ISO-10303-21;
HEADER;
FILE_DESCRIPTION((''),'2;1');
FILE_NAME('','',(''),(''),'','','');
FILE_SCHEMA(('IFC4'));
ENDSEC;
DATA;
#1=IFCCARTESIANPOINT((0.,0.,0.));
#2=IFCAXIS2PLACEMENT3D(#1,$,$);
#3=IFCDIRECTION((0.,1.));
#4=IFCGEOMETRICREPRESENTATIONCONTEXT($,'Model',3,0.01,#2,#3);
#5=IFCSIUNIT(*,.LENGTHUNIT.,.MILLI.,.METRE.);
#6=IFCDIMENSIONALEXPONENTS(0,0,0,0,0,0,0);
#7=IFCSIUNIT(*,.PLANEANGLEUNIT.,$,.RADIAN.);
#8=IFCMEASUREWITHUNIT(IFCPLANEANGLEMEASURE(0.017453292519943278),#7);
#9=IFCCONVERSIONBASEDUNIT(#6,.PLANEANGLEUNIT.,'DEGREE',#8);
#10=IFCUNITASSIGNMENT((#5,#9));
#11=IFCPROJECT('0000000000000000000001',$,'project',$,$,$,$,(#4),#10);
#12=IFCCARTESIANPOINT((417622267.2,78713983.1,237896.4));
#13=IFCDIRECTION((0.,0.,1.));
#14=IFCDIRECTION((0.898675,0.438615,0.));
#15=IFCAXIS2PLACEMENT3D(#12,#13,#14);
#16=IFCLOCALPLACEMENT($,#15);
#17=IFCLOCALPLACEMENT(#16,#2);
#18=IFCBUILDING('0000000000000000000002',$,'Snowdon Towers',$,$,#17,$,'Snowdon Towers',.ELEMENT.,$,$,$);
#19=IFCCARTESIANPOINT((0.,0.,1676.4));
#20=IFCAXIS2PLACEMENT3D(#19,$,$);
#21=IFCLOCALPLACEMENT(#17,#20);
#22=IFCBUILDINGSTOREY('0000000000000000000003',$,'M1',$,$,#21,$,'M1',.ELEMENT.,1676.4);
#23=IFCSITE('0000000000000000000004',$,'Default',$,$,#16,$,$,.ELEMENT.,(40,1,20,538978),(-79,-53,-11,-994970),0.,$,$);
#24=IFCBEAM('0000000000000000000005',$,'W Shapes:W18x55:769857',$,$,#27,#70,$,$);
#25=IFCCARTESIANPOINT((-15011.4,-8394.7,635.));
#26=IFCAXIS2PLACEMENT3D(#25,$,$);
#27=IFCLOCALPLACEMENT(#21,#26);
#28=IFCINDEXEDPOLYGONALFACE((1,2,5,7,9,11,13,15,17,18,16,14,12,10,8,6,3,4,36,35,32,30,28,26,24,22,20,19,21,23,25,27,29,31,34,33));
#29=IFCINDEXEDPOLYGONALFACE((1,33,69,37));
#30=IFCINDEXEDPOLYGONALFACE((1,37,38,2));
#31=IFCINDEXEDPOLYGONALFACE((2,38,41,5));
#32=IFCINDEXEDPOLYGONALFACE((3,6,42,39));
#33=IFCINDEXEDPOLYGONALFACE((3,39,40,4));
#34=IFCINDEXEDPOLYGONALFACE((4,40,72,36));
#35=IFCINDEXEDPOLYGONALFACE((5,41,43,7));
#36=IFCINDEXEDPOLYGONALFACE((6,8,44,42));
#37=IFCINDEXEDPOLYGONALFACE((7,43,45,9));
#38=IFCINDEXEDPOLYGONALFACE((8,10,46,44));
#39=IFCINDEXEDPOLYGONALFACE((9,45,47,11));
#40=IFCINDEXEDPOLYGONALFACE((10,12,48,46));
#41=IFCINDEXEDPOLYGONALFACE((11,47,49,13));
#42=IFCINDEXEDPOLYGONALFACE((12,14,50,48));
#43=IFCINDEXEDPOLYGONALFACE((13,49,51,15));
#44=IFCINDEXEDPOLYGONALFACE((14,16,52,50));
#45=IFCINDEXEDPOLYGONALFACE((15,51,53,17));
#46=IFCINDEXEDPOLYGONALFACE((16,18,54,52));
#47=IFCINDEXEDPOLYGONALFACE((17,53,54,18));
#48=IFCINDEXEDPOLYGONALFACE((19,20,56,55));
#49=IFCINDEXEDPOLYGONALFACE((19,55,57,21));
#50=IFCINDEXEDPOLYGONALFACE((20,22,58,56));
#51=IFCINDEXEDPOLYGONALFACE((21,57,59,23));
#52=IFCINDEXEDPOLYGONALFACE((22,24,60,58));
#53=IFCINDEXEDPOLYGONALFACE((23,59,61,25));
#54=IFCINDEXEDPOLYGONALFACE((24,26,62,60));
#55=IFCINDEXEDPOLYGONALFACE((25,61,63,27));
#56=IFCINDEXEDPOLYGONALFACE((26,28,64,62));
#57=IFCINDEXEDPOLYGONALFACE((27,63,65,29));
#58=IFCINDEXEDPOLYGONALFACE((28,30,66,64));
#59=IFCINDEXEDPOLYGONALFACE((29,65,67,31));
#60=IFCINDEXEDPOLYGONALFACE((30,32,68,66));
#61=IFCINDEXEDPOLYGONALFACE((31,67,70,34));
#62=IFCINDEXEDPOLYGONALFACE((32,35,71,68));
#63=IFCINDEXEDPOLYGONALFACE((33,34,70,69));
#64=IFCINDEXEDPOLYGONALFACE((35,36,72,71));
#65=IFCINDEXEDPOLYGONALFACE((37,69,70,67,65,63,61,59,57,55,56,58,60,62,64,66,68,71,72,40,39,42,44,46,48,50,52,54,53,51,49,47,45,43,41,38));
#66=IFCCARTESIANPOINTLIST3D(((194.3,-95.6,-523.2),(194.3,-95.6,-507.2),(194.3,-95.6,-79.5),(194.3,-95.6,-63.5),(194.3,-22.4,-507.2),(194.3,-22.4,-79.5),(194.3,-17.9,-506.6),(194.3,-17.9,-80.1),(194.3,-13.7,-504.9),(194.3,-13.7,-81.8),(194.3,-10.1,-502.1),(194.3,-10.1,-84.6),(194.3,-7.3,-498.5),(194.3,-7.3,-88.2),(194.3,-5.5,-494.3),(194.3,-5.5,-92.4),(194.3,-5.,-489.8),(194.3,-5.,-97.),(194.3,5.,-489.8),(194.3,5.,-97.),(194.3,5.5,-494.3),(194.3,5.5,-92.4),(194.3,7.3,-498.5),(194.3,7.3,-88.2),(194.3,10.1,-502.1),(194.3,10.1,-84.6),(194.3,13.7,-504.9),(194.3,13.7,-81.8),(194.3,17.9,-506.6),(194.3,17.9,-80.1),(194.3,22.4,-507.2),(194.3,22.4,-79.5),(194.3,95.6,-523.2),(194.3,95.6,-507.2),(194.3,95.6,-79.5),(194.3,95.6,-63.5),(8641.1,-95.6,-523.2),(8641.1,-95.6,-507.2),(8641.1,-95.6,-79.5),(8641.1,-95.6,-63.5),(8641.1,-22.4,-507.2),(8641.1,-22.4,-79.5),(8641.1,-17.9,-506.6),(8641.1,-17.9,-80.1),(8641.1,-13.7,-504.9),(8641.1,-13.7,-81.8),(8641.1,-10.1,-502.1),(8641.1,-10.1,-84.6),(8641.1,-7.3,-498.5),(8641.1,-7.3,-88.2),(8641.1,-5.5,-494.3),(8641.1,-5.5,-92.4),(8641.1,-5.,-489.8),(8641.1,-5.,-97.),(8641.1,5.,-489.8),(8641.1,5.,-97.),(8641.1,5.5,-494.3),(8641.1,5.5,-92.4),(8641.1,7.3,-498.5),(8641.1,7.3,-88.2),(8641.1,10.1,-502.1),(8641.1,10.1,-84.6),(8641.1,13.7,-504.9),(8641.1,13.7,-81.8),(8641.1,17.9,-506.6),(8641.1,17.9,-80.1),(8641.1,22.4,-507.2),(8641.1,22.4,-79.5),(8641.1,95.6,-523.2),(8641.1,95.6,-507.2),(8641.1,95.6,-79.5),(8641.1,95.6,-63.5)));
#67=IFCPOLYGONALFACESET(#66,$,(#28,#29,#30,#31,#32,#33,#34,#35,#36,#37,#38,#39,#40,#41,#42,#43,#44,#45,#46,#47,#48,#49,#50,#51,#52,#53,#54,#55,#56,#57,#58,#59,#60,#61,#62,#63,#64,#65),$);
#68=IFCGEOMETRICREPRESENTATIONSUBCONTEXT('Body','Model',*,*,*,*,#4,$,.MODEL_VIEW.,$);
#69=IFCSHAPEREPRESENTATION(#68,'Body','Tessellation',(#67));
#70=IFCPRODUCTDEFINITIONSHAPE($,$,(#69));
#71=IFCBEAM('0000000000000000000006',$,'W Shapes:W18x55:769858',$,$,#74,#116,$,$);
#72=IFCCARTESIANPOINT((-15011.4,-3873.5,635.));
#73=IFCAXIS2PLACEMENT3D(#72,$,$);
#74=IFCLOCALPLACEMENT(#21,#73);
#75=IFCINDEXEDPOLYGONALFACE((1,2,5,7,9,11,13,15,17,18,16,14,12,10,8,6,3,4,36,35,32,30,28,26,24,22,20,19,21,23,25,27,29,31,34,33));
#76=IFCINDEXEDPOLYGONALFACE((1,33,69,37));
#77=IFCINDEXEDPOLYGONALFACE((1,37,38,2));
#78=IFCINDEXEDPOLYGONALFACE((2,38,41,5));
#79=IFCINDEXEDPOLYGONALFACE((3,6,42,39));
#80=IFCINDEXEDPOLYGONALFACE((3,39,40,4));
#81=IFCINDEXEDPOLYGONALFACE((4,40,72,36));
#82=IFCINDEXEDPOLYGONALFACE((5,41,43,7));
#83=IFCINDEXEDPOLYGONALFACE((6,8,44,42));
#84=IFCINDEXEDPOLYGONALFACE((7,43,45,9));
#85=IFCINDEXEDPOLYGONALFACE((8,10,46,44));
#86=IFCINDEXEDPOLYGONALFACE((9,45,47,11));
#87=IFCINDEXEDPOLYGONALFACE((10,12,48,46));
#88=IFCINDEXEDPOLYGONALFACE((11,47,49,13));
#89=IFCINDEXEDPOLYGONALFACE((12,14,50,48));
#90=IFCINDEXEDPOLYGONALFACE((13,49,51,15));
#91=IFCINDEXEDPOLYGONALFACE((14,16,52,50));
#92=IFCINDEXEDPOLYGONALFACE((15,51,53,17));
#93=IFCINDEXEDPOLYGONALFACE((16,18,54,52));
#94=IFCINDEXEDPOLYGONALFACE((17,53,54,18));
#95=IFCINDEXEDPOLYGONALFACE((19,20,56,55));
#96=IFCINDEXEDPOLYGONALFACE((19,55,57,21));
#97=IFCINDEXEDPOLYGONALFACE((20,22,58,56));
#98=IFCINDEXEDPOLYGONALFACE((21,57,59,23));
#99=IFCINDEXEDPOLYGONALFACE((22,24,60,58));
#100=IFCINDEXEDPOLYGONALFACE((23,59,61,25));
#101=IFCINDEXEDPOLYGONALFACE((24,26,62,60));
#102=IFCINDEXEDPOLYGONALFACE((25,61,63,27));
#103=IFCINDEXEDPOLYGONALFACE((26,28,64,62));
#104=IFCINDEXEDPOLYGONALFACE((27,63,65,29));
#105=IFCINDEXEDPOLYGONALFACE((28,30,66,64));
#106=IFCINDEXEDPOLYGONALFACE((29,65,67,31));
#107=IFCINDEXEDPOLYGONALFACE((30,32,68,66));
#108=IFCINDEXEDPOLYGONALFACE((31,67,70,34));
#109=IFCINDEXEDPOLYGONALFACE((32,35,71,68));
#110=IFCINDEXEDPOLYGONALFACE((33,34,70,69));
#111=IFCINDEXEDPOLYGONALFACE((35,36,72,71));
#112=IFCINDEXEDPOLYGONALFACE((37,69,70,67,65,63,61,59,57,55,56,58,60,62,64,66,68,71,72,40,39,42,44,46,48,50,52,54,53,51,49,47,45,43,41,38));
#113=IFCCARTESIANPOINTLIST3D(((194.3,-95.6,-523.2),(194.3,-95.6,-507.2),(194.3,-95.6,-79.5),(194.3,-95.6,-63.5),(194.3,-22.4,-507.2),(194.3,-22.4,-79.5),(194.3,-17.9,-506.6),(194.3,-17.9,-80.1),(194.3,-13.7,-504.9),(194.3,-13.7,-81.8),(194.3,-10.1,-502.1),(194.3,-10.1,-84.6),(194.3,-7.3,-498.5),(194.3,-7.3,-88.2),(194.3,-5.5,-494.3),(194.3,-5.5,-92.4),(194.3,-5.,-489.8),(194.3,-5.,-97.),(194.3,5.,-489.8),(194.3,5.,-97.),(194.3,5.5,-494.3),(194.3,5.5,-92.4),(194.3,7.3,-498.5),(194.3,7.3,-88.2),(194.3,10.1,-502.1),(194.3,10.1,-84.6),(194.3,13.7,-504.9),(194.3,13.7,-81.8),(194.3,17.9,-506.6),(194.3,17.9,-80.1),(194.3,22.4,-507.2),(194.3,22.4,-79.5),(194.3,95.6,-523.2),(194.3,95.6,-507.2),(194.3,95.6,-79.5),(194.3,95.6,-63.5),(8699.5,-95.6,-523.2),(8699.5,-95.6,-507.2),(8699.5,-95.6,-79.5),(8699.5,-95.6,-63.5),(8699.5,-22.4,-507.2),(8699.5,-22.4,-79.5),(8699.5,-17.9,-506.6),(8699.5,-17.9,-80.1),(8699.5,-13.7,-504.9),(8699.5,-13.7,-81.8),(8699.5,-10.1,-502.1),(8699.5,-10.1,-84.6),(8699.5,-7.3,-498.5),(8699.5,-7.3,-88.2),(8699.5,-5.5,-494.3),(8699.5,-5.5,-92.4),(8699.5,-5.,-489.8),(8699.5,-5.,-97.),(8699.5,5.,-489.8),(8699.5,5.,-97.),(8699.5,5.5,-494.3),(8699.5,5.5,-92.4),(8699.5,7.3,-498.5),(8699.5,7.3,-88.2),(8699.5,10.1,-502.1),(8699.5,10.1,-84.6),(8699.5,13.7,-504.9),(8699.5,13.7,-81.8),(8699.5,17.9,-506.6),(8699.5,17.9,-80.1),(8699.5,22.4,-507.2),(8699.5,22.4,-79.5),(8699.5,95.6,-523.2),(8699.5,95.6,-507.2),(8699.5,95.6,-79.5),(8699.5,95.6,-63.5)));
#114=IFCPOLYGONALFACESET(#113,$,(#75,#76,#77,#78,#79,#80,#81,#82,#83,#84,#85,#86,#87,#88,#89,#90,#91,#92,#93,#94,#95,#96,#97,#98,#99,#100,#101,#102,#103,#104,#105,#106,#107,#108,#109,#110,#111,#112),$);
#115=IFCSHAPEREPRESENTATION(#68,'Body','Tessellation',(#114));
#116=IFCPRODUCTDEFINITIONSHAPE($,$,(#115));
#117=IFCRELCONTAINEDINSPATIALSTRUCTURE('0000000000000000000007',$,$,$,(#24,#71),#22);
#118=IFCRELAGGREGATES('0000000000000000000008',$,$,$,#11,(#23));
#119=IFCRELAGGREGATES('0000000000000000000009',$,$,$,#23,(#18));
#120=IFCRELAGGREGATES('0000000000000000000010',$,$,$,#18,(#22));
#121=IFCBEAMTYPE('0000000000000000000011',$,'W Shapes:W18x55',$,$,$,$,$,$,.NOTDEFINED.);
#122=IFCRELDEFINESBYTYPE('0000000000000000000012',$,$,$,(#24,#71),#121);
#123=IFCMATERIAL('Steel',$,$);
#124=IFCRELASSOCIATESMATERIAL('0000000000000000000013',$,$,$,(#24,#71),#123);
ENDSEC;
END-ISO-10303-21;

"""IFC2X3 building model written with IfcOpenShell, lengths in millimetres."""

from ifc_helpers import new_model, entity, si_unit, converted_unit, direction, frame, frame_2d, origin, place, context, subcontext, project, spatial, i_section, extrude, material, type_object, element, save


model = new_model("IFC2X3")

# Units and contexts
model_context = context("Model", 3, precision=0.01, world=origin(), true_north=direction((0.0, 1.0)))
body_context = subcontext(model_context, "Body", "Model", "MODEL_VIEW")
ifc_project = project(units=[si_unit("LENGTHUNIT", "METRE", prefix="MILLI"), converted_unit("PLANEANGLEUNIT", "DEGREE", entity("IfcPlaneAngleMeasure", 0.017453292519943278), si_unit("PLANEANGLEUNIT", "RADIAN"), dimensions=[0, 0, 0, 0, 0, 0, 0])], contexts=[model_context])

# Site, building, storey
site_placement = place(None, frame((417622267.2, 78713983.1, 237896.4), z_axis=(0.0, 0.0, 1.0), x_axis=(0.898675, 0.438615, 0.0)))
site = spatial("IfcSite", under=ifc_project, at=site_placement, Name="Default", CompositionType="ELEMENT", RefLatitude=(40, 1, 20, 538978), RefLongitude=(-79, -53, -11, -994970), RefElevation=0.0)
building_placement = place(site_placement, origin())
building = spatial("IfcBuilding", under=site, at=building_placement, Name="Snowdon Towers", LongName="Snowdon Towers", CompositionType="ELEMENT")
storey_placement = place(building_placement, frame((0.0, 0.0, 1676.4)))
storey = spatial("IfcBuildingStorey", under=building, at=storey_placement, Name="M1", LongName="M1", CompositionType="ELEMENT", Elevation=1676.4)

# Shared definitions
ifc_material_1 = material(Name="Steel")

# Beams
beam_type_1 = type_object("IfcBeamType", Name="W Shapes:W18x55", PredefinedType="NOTDEFINED")
beam_1_placement = place(storey_placement, frame((-15011.4, -8394.7, 635.0)))
element("IfcBeam", 1, at=beam_1_placement, inside=storey, type_object=beam_type_1, material=ifc_material_1, Name="W Shapes:W18x55:769857", context=body_context, shape_type="SweptSolid", body=[
    extrude(i_section(OverallWidth=191.3, OverallDepth=459.7, WebThickness=9.9, FlangeThickness=16.0, FilletRadius=17.5, at=frame_2d((0.0, 0.0), x_axis=(0.0, 1.0))), frame((194.3, 0.0, -293.4), z_axis=(1.0, 0.0, 0.0), x_axis=(0.0, 0.0, -1.0)), (0.0, 0.0, 1.0), 8446.8),
])
beam_2_placement = place(storey_placement, frame((-15011.4, -3873.5, 635.0)))
element("IfcBeam", 2, at=beam_2_placement, inside=storey, type_object=beam_type_1, material=ifc_material_1, Name="W Shapes:W18x55:769858", context=body_context, shape_type="SweptSolid", body=[
    extrude(i_section(OverallWidth=191.3, OverallDepth=459.7, WebThickness=9.9, FlangeThickness=16.0, FilletRadius=17.5, at=frame_2d((0.0, 0.0), x_axis=(0.0, 1.0))), frame((194.3, 0.0, -293.4), z_axis=(1.0, 0.0, 0.0), x_axis=(0.0, 0.0, -1.0)), (0.0, 0.0, 1.0), 8505.2),
])

save(model, "model.ifc")
